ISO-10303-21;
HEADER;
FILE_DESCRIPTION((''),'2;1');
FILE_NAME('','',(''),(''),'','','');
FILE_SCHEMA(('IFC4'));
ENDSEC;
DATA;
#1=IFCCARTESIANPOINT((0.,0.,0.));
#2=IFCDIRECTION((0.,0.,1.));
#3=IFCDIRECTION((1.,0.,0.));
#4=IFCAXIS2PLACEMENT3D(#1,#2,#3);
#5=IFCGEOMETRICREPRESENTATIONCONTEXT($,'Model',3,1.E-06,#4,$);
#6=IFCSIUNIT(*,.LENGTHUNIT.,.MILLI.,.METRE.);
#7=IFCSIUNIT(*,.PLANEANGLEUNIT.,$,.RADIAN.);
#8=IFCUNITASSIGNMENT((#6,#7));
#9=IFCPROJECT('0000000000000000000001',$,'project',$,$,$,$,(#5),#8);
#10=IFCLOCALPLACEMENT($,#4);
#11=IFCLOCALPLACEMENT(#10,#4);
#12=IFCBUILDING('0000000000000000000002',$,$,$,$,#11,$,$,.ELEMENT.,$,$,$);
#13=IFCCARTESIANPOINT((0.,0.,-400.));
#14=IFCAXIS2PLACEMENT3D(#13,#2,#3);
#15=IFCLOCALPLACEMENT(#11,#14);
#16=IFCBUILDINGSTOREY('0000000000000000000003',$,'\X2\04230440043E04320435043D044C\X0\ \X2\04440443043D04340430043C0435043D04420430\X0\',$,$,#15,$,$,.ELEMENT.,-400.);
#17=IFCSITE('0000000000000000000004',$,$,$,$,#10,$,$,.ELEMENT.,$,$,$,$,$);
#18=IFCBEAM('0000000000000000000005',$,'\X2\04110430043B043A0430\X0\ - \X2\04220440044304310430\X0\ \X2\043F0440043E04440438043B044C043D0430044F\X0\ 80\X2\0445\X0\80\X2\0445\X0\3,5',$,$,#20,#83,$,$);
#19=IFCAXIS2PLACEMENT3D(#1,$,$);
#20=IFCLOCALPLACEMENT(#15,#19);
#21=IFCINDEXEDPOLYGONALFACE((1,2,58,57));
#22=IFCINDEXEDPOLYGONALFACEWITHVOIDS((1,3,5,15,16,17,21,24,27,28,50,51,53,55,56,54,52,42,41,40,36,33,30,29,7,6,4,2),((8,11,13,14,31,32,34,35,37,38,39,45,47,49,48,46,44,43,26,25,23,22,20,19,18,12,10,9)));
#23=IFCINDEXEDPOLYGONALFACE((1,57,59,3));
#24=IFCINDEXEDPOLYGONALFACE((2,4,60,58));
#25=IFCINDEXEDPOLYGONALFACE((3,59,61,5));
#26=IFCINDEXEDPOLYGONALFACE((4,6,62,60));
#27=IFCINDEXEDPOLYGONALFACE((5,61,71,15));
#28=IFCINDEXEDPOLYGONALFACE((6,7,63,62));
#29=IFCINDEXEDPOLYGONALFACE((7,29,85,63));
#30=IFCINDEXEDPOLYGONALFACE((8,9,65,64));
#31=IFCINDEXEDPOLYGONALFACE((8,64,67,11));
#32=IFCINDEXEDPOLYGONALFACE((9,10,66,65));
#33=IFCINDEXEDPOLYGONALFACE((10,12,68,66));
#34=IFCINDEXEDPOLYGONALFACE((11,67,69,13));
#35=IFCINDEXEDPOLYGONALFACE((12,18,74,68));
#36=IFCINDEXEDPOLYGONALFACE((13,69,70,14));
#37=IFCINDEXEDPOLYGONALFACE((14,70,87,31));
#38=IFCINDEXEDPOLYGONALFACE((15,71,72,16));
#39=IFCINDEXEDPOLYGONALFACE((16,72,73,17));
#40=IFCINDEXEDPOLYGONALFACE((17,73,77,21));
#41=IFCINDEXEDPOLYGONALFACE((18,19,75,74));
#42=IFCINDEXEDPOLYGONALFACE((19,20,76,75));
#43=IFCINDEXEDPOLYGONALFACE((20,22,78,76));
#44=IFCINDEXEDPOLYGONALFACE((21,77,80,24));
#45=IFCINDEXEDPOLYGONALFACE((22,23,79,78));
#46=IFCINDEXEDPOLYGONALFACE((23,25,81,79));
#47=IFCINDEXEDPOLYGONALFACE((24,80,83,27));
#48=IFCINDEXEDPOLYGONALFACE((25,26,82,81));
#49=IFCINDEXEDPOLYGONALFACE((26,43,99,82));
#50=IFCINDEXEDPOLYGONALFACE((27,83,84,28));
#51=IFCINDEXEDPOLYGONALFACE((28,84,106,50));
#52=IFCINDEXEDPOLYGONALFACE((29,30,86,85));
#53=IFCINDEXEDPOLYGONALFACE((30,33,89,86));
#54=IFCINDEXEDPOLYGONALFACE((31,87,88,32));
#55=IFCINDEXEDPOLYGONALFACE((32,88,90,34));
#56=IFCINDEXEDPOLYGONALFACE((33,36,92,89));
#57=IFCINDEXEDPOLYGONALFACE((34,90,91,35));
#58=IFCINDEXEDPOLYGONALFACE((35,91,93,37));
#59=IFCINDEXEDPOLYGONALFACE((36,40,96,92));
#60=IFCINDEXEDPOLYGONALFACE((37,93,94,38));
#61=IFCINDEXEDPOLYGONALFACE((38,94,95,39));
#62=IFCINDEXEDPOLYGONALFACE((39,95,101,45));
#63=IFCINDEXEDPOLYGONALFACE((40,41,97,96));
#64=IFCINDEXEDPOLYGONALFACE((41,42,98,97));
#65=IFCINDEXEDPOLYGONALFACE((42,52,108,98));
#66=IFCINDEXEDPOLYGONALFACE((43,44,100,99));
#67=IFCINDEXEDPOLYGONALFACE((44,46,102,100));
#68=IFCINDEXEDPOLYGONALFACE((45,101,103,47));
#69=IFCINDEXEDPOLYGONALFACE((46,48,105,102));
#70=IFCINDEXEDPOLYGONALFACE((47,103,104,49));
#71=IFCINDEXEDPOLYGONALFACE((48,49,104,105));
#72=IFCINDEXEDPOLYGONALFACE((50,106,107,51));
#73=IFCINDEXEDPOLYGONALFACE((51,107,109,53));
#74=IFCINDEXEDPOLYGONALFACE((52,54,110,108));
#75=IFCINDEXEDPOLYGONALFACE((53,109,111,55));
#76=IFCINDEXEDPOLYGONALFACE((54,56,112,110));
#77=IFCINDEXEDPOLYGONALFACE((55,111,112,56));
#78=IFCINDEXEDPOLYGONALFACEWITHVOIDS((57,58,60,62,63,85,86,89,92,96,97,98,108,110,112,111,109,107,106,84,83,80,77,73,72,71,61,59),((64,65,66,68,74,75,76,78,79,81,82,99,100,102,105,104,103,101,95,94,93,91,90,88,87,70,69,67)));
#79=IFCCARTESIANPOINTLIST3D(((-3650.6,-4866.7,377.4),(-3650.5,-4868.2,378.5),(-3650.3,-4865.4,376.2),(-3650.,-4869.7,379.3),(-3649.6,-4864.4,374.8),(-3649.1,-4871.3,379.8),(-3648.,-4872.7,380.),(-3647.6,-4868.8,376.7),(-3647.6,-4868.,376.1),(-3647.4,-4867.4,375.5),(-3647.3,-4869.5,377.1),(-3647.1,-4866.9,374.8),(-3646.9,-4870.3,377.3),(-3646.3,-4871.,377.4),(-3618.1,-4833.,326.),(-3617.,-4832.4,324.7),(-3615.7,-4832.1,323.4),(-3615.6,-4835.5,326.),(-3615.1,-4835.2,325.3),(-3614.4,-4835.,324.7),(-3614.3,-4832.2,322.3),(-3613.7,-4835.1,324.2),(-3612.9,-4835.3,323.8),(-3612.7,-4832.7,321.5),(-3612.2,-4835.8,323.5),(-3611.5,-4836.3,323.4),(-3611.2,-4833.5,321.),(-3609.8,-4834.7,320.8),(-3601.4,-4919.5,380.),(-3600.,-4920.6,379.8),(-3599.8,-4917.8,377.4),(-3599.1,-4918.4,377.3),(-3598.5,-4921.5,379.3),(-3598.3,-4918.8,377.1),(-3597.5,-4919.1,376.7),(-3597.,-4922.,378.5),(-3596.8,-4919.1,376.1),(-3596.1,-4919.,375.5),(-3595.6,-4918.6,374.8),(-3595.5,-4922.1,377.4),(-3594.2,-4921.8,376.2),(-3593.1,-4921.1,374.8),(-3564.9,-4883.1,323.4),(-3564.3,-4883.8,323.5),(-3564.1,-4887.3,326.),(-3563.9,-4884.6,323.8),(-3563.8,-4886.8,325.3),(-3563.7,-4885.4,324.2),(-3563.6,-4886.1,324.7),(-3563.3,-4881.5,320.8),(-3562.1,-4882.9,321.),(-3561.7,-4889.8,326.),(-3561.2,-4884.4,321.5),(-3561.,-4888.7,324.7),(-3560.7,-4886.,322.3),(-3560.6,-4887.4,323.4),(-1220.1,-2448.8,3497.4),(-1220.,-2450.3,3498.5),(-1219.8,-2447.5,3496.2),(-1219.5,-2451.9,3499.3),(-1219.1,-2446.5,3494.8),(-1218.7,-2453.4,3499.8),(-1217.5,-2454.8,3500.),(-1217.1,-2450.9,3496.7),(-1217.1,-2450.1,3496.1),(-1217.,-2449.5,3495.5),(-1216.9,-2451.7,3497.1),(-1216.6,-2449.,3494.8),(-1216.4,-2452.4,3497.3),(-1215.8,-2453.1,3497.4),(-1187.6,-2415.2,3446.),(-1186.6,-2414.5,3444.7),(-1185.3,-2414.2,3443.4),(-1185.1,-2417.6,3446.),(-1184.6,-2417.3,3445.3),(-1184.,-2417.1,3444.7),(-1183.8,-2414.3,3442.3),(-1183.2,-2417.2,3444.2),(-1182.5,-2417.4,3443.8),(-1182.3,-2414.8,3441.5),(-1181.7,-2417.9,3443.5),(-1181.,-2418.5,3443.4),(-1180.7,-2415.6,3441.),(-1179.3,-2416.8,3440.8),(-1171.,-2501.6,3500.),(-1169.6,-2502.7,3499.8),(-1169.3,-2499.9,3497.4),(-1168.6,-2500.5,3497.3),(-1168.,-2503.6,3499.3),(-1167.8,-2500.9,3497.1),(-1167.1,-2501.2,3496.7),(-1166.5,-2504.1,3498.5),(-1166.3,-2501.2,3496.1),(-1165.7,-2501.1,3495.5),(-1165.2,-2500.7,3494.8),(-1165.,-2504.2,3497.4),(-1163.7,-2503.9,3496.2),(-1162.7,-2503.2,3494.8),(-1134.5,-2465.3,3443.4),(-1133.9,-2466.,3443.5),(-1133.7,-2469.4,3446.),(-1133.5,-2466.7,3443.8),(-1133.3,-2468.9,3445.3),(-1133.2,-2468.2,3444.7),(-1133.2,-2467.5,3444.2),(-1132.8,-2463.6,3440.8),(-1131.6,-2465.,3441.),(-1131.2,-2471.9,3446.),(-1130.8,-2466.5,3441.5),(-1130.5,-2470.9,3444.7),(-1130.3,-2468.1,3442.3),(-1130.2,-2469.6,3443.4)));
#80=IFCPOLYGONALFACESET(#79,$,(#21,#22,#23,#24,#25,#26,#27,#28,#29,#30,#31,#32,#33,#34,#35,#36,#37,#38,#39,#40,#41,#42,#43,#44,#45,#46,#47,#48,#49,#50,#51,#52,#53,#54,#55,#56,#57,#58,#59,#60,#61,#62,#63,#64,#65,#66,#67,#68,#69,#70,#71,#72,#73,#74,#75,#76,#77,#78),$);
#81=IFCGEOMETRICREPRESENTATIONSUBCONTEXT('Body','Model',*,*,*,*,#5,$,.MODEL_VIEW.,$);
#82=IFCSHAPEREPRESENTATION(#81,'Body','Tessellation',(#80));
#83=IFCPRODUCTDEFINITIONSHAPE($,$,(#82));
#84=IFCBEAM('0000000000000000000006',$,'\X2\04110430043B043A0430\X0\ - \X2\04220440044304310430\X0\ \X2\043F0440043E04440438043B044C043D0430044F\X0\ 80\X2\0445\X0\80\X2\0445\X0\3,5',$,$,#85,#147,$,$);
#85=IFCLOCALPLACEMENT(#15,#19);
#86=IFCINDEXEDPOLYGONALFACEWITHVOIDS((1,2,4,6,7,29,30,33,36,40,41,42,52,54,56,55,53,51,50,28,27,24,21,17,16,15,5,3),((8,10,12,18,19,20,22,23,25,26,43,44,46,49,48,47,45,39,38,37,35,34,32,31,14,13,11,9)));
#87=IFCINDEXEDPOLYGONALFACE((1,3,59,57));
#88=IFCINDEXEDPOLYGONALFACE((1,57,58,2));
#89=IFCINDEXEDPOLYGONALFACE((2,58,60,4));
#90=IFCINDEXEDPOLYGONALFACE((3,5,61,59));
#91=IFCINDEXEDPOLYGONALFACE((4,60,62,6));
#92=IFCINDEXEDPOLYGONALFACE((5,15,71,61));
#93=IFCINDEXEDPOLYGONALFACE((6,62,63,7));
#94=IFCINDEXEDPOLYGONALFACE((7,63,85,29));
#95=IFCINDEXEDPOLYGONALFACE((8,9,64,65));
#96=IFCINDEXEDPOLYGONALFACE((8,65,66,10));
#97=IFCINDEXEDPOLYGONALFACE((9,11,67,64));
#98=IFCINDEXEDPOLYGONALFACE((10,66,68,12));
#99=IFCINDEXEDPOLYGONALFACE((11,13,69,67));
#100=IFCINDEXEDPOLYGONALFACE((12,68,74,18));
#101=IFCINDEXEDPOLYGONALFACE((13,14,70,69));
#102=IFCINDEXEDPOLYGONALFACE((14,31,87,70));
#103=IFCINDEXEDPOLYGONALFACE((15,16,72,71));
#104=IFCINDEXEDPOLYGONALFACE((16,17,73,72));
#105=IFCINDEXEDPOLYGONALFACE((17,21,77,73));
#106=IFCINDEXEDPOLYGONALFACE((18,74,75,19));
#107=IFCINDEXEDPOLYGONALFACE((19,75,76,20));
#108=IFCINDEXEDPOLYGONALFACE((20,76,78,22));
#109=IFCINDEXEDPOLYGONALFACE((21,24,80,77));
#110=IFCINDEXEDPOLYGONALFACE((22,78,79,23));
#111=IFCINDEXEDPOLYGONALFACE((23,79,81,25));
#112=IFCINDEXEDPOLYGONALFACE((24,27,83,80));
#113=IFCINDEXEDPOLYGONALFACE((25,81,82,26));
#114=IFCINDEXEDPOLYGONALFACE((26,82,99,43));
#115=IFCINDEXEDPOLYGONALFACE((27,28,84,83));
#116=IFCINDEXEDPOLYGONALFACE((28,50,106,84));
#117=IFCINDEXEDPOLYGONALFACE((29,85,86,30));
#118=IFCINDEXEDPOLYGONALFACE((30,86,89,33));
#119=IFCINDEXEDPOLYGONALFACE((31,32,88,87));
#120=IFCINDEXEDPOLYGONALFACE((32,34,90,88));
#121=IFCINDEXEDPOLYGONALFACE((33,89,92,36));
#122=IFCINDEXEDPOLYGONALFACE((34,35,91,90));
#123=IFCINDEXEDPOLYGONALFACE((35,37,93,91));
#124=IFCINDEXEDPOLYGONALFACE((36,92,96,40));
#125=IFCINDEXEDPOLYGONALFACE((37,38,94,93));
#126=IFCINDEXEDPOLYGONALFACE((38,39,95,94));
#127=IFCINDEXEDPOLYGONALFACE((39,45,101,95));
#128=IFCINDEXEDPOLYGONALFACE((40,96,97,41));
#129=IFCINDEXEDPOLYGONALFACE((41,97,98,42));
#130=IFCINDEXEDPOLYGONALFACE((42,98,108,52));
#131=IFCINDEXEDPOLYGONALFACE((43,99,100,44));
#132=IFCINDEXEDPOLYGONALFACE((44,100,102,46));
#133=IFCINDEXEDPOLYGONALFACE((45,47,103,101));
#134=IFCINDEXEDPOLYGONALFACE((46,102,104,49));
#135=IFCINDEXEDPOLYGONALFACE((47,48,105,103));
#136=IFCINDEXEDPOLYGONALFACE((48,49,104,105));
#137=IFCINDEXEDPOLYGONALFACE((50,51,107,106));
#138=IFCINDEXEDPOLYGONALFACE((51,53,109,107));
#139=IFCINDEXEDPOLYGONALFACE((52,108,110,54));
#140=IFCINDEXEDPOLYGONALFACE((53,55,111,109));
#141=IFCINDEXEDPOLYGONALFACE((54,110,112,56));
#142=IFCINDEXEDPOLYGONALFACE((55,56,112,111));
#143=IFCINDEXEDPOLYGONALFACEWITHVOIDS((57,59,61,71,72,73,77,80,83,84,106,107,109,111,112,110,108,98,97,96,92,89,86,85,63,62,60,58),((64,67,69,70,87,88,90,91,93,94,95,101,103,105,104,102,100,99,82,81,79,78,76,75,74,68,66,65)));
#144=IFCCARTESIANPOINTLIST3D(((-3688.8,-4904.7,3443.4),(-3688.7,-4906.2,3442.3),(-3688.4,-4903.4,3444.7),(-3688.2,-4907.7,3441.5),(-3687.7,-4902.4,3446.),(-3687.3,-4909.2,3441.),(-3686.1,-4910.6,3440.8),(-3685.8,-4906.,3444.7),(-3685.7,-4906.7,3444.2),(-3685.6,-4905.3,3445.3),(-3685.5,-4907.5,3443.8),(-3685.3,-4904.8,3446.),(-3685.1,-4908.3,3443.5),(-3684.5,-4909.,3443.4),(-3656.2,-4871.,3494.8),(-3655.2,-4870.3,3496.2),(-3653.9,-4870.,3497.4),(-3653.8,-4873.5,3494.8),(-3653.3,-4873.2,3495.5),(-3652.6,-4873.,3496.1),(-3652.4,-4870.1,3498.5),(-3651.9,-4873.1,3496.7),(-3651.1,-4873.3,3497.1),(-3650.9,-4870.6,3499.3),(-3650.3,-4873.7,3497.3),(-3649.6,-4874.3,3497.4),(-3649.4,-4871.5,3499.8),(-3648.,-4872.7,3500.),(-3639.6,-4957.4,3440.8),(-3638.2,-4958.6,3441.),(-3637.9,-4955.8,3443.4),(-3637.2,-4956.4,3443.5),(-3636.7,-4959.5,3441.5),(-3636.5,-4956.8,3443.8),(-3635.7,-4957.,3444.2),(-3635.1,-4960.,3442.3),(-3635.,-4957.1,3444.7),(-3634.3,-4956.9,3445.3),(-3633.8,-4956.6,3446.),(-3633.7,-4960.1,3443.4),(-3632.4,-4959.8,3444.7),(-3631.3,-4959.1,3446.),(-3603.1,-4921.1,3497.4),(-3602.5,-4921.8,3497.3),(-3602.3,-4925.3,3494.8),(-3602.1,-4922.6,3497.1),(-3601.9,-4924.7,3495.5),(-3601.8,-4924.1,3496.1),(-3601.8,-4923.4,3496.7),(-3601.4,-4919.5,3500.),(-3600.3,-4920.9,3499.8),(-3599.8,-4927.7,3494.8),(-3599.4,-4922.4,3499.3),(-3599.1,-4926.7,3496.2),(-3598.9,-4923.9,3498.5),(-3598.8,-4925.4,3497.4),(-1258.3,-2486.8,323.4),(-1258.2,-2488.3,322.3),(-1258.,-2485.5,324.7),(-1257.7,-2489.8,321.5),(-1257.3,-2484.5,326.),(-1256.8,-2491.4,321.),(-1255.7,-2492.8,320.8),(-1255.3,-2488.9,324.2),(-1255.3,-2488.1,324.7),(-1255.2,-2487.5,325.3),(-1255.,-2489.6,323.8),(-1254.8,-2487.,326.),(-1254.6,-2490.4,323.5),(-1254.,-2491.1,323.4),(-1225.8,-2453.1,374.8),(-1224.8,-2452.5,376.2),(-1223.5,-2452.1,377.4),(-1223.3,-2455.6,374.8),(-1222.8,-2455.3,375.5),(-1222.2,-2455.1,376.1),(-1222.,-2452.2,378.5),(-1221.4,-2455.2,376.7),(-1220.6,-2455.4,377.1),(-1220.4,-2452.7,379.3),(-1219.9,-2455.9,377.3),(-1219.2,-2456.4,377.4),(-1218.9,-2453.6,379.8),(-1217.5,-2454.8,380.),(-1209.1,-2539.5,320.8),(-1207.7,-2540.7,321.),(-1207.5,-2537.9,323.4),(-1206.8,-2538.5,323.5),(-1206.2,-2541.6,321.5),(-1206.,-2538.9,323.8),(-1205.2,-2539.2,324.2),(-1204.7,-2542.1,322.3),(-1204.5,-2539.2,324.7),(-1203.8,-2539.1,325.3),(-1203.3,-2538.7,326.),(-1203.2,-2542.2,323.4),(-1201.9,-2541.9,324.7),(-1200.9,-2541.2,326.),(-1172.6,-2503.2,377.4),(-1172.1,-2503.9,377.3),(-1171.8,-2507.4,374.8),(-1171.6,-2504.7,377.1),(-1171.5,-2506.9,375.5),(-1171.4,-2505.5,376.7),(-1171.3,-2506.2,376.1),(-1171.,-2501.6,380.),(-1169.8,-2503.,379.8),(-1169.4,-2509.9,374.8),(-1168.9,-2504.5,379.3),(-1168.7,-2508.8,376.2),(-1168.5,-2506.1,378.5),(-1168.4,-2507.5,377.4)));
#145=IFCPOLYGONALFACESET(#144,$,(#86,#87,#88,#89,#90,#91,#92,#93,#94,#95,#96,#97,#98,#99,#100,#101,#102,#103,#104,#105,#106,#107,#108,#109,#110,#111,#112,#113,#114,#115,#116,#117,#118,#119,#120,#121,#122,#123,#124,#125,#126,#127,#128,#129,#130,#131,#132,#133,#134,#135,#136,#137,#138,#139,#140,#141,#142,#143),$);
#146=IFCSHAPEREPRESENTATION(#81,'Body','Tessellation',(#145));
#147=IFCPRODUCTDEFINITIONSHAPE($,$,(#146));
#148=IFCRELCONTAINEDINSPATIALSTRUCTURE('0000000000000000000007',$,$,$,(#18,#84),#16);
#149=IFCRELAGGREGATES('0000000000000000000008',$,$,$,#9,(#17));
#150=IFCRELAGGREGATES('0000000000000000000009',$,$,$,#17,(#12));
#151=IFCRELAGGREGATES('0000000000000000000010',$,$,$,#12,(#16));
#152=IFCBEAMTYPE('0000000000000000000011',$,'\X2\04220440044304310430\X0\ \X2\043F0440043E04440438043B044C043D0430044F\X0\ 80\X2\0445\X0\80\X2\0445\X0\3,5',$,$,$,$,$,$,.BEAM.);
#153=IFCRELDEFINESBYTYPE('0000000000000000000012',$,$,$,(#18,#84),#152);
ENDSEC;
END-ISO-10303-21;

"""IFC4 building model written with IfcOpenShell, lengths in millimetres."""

from ifc_helpers import new_model, si_unit, frame, origin_with_axes, place, context, subcontext, project, spatial, line, arc, indexed_curve, outline, extrude, source, transform, mapped, type_object, element, save


model = new_model("IFC4")

# Units and contexts
model_context = context("Model", 3, precision=1e-06, world=origin_with_axes())
body_context = subcontext(model_context, "Body", "Model", "MODEL_VIEW")
ifc_project = project(units=[si_unit("LENGTHUNIT", "METRE", prefix="MILLI"), si_unit("PLANEANGLEUNIT", "RADIAN")], contexts=[model_context])

# Site, building, storey
site_placement = place(None, origin_with_axes())
site = spatial("IfcSite", under=ifc_project, at=site_placement, CompositionType="ELEMENT")
building_placement = place(site_placement, origin_with_axes())
building = spatial("IfcBuilding", under=site, at=building_placement, CompositionType="ELEMENT")
storey_placement = place(building_placement, frame((0.0, 0.0, -400.0), z_axis=(0.0, 0.0, 1.0), x_axis=(1.0, 0.0, 0.0)))
storey = spatial("IfcBuildingStorey", under=building, at=storey_placement, Name="Уровень фундамента", CompositionType="ELEMENT", Elevation=-400.0)

# Beams
beam_type_1 = type_object("IfcBeamType", Name="Труба профильная 80х80х3,5", PredefinedType="BEAM")
shared_shape_1 = source(origin_with_axes(), body_context, "Body", "SweptSolid", [
    extrude(outline(indexed_curve([(-40.0, -73.0), (-37.9, -77.9), (-33.0, -80.0), (33.0, -80.0), (37.9, -77.9), (40.0, -73.0), (40.0, -7.0), (37.9, -2.1), (33.0, 0.0), (-33.0, 0.0), (-37.9, -2.1), (-40.0, -7.0)], segments=[arc(1, 2, 3), line(3, 4), arc(4, 5, 6), line(6, 7), arc(7, 8, 9), line(9, 10), arc(10, 11, 12), line(12, 1)]), holes=[indexed_curve([(-36.5, -7.0), (-35.5, -4.5), (-33.0, -3.5), (33.0, -3.5), (35.5, -4.5), (36.5, -7.0), (36.5, -73.0), (35.5, -75.5), (33.0, -76.5), (-33.0, -76.5), (-35.5, -75.5), (-36.5, -73.0)], segments=[arc(1, 2, 3), line(3, 4), arc(4, 5, 6), line(6, 7), arc(7, 8, 9), line(9, 10), arc(10, 11, 12), line(12, 1)])]), origin_with_axes(), (0.0, 0.0, -1.0), 4635.5),
])
for number, where, z_axis, x_axis, name in (
    (1, (-3624.7, -4896.1, 380.0), (-0.524317, -0.521603, -0.673069), (0.70527, -0.708939, 0.0), "Балка - Труба профильная 80х80х3,5"),
    (2, (-3624.7, -4896.1, 3500.0), (-0.524317, -0.521603, 0.673069), (0.70527, -0.708939, 0.0), "Балка - Труба профильная 80х80х3,5"),
):
    element("IfcBeam", number, at=place(storey_placement, frame(where, z_axis=z_axis, x_axis=x_axis)), inside=storey, type_object=beam_type_1, Name=name, context=body_context, shape_type="MappedRepresentation", body=[
        mapped(shared_shape_1, transform((0.0, 0.0, 0.0), x_axis=(1.0, 0.0, 0.0), y_axis=(0.0, 1.0, 0.0), z_axis=(0.0, 0.0, 1.0), scale=1.0)),
    ])

save(model, "model.ifc")
